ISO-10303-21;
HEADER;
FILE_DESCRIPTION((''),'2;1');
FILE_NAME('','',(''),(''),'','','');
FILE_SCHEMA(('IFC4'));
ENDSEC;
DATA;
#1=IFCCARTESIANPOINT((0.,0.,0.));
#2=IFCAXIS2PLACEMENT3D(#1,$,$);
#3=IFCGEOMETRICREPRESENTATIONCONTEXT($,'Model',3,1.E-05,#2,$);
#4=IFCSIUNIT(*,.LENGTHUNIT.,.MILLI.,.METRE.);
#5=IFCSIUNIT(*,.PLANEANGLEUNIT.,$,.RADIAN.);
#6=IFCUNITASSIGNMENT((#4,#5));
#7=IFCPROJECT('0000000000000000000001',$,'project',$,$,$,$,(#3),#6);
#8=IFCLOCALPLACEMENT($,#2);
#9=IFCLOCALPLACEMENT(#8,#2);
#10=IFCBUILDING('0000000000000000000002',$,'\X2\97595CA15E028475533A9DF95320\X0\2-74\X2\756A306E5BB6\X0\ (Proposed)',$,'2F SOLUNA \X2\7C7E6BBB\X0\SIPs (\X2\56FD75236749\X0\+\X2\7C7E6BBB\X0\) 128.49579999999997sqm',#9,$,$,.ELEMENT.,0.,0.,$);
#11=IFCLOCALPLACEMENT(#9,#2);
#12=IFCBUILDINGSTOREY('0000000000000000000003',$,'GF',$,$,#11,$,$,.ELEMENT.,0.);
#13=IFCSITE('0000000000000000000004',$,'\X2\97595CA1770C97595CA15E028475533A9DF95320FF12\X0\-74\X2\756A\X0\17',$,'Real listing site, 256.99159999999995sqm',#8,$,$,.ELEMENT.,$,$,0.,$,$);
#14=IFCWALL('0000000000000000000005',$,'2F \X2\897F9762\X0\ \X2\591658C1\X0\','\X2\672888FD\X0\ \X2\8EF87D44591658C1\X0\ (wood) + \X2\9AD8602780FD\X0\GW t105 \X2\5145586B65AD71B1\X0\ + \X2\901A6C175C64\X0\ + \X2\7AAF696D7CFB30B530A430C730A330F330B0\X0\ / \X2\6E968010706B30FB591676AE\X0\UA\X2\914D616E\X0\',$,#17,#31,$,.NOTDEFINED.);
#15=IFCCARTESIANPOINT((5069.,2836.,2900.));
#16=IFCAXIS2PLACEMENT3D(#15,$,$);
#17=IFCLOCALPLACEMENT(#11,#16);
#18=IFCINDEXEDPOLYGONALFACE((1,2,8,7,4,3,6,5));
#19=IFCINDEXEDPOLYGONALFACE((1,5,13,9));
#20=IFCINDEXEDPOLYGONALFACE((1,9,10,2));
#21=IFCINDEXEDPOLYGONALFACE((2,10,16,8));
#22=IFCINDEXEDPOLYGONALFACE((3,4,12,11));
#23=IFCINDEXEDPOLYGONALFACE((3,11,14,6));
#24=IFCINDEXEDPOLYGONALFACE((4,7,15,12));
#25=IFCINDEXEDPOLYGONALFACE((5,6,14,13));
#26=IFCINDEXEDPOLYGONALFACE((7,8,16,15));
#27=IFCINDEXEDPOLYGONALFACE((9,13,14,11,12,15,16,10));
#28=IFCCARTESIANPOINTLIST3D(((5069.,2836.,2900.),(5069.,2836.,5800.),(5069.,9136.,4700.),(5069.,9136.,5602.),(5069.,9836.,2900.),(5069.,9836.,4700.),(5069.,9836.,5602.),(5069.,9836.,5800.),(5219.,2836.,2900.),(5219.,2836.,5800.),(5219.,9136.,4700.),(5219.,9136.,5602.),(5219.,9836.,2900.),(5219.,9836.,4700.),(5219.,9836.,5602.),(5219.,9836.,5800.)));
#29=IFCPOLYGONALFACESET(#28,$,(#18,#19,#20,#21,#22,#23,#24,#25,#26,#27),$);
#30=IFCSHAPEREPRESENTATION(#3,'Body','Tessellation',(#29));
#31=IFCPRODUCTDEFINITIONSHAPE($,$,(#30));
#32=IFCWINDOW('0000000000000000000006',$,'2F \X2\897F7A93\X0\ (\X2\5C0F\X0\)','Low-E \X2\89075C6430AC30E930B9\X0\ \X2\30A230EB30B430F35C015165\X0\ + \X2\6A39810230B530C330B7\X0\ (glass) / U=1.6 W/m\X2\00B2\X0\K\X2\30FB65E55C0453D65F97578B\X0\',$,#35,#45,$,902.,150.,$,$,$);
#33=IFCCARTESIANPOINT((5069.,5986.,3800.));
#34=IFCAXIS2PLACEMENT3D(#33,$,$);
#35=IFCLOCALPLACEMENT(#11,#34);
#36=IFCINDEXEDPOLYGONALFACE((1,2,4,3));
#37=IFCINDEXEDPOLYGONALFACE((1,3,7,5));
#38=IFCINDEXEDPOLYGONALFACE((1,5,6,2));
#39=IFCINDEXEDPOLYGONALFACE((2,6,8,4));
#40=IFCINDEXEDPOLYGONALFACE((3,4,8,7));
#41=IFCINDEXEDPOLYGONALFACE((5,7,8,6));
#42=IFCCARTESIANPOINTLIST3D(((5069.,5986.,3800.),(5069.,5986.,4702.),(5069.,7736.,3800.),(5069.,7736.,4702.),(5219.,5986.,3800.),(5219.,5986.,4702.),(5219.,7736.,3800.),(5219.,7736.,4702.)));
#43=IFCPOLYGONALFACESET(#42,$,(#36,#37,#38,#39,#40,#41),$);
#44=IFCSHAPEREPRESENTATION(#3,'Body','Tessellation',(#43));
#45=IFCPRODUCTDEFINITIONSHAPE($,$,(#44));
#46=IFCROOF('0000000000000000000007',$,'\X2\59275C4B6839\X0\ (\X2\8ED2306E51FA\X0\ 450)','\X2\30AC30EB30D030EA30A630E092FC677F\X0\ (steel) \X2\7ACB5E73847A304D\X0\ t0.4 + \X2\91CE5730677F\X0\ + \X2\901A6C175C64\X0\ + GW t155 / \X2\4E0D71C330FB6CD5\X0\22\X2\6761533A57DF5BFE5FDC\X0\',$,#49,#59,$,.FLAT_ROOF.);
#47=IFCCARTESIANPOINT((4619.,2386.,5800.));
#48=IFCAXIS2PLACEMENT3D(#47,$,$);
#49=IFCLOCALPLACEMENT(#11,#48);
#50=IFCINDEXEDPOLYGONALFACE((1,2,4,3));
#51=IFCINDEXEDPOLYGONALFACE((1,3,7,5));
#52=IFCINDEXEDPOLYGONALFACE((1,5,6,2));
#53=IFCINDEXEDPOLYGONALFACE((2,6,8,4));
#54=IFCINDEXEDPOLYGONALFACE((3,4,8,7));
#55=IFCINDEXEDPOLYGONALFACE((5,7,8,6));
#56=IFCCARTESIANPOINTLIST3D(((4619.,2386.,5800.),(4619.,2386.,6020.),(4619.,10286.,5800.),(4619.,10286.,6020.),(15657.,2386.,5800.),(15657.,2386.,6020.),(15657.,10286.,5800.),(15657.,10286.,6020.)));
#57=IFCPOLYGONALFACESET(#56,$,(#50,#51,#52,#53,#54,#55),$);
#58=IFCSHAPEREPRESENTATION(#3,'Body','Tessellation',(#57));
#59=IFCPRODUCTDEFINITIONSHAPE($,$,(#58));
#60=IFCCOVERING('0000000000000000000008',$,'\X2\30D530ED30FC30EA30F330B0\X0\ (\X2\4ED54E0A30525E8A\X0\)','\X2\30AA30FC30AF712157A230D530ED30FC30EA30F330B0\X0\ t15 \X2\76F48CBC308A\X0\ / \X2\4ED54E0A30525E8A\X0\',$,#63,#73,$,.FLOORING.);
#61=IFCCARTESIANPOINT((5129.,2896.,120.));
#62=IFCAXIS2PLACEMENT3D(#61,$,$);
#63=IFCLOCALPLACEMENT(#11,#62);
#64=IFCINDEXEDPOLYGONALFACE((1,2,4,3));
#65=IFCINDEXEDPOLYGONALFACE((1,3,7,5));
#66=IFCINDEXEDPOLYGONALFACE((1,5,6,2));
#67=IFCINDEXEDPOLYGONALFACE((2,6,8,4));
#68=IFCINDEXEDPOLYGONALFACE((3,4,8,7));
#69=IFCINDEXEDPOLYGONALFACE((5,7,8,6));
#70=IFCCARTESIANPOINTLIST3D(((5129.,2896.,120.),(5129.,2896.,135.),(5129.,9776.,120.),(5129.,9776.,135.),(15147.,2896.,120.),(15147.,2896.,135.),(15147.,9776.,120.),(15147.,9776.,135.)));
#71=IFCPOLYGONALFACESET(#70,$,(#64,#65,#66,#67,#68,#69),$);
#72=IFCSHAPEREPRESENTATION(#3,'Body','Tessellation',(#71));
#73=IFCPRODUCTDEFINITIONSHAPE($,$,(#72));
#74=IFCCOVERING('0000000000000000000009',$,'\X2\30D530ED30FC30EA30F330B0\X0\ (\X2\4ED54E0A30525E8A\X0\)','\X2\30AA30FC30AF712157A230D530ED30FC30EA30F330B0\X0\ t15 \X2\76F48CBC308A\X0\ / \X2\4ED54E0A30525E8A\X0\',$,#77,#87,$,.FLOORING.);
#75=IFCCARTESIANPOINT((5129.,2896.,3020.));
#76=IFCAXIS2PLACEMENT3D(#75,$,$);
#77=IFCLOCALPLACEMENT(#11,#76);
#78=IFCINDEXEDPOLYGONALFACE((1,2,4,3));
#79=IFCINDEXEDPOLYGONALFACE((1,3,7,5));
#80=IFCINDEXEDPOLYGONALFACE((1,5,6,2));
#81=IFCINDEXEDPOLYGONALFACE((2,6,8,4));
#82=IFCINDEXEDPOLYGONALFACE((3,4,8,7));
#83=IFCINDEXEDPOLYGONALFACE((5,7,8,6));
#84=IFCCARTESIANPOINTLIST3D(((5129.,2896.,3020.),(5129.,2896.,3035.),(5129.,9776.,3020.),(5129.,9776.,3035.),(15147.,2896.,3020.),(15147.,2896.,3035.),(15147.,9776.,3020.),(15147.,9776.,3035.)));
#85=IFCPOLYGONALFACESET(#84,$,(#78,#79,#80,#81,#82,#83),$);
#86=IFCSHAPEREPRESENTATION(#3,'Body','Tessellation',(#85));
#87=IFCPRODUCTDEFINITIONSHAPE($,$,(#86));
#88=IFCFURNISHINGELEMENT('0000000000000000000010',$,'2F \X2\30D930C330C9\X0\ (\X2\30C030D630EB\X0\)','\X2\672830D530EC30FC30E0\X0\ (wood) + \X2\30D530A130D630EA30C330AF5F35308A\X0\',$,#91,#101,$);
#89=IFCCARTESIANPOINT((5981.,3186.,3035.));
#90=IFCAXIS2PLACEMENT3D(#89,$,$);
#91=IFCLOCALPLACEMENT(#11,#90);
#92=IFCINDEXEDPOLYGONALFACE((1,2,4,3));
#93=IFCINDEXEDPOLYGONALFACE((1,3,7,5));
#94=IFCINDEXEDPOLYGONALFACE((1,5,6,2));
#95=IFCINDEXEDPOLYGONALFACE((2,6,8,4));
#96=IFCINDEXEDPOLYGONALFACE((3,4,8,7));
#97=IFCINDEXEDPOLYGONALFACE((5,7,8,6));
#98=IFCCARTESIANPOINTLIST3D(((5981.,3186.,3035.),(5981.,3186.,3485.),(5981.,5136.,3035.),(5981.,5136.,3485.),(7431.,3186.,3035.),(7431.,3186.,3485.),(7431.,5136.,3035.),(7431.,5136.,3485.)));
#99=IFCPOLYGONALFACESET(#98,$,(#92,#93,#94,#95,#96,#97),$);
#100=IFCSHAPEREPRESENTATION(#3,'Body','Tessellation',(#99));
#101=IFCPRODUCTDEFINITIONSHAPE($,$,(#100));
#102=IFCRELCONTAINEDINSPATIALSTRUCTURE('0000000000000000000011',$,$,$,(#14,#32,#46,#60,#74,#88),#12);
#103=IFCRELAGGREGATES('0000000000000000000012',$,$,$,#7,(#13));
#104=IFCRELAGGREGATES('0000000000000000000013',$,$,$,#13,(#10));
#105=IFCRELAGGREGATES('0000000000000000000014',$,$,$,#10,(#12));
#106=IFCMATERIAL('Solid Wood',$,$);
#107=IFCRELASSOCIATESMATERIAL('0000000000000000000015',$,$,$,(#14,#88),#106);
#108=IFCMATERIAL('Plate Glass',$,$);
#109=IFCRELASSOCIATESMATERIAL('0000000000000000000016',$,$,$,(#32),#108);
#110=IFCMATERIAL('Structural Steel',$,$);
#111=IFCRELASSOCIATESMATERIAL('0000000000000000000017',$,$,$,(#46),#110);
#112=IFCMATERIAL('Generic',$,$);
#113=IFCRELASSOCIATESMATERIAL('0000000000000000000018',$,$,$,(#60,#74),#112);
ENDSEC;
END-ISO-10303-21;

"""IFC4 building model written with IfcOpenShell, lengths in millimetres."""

from ifc_helpers import new_model, si_unit, frame, frame_2d, origin, place, context, project, spatial, rectangle, extrude, material, element, fill, save


model = new_model("IFC4")

# Units and contexts
model_context = context("Model", 3, precision=1e-05, world=origin())
ifc_project = project(units=[si_unit("LENGTHUNIT", "METRE", prefix="MILLI"), si_unit("PLANEANGLEUNIT", "RADIAN")], contexts=[model_context])

# Site, building, storey
site_placement = place(None, origin())
site = spatial("IfcSite", under=ifc_project, at=site_placement, Name="静岡県静岡市葵区鷹匠２-74番17", ObjectType="Real listing site, 256.99159999999995sqm", CompositionType="ELEMENT", RefElevation=0.0)
building_placement = place(site_placement, origin())
building = spatial("IfcBuilding", under=site, at=building_placement, Name="静岡市葵区鷹匠2-74番の家 (Proposed)", ObjectType="2F SOLUNA 籾殻SIPs (国産杉+籾殻) 128.49579999999997sqm", CompositionType="ELEMENT", ElevationOfRefHeight=0.0, ElevationOfTerrain=0.0)
storey_placement = place(building_placement, origin())
storey = spatial("IfcBuildingStorey", under=building, at=storey_placement, Name="GF", CompositionType="ELEMENT", Elevation=0.0)

# Shared definitions
ifc_material_1 = material(Name="Solid Wood")

# Shared definitions
ifc_material_2 = material(Name="Plate Glass")

# Wall, opening, window
wall_1_placement = place(storey_placement, frame((5069.0, 2836.0, 2900.0)))
wall_1 = element("IfcWall", 1, at=wall_1_placement, inside=storey, material=ifc_material_1, Name="2F 西面 外壁", Description="木製 軸組外壁 (wood) + 高性能GW t105 充填断熱 + 通気層 + 窯業系サイディング / 準耐火・外皮UA配慮", PredefinedType="NOTDEFINED", context=model_context, shape_type="SweptSolid", body=[
    extrude(rectangle(XDim=150.0, YDim=7000.0, at=frame_2d((75.0, 3500.0))), frame((5069.0, 2836.0, 2900.0)), (0.0, 0.0, 1.0), 2900.0),
])
opening_1_placement = place(storey_placement, frame((5069.0, 5986.0, 3800.0)))
opening_1 = element("IfcOpeningElement", 2, at=opening_1_placement, cuts=wall_1, PredefinedType="NOTDEFINED", context=model_context, shape_type="SweptSolid", body=[
    extrude(rectangle(XDim=150.0, YDim=1750.0, at=frame_2d((75.0, 875.0))), frame((5069.0, 5986.0, 3800.0)), (0.0, 0.0, 1.0), 902.0),
])
window_1_placement = place(storey_placement, frame((5069.0, 5986.0, 3800.0)))
window_1 = element("IfcWindow", 3, at=window_1_placement, inside=storey, material=ifc_material_2, Name="2F 西窓 (小)", Description="Low-E 複層ガラス アルゴン封入 + 樹脂サッシ (glass) / U=1.6 W/m²K・日射取得型", OverallHeight=902.0, OverallWidth=150.0, context=model_context, shape_type="SweptSolid", body=[
    extrude(rectangle(XDim=150.0, YDim=1750.0, at=frame_2d((75.0, 875.0))), frame((5069.0, 5986.0, 3800.0)), (0.0, 0.0, 1.0), 902.0),
])
fill(opening_1, window_1)

# Roof
ifc_material_3 = material(Name="Structural Steel")
roof_placement = place(storey_placement, frame((4619.0, 2386.0, 5800.0)))
element("IfcRoof", 4, at=roof_placement, inside=storey, material=ifc_material_3, Name="大屋根 (軒の出 450)", Description="ガルバリウム鋼板 (steel) 立平葺き t0.4 + 野地板 + 通気層 + GW t155 / 不燃・法22条区域対応", PredefinedType="FLAT_ROOF", context=model_context, shape_type="SweptSolid", body=[
    extrude(rectangle(XDim=11038.0, YDim=7900.0, at=frame_2d((5519.0, 3950.0))), frame((4619.0, 2386.0, 5800.0)), (0.0, 0.0, 1.0), 220.0),
])

# Coverings
ifc_material_4 = material(Name="Generic")
covering_1_placement = place(storey_placement, frame((5129.0, 2896.0, 120.0)))
element("IfcCovering", 5, at=covering_1_placement, inside=storey, material=ifc_material_4, Name="フローリング (仕上げ床)", Description="オーク無垢フローリング t15 直貼り / 仕上げ床", PredefinedType="FLOORING", context=model_context, shape_type="SweptSolid", body=[
    extrude(rectangle(XDim=10018.0, YDim=6880.0, at=frame_2d((5009.0, 3440.0))), frame((5129.0, 2896.0, 120.0)), (0.0, 0.0, 1.0), 15.0),
])
covering_2_placement = place(storey_placement, frame((5129.0, 2896.0, 3020.0)))
element("IfcCovering", 6, at=covering_2_placement, inside=storey, material=ifc_material_4, Name="フローリング (仕上げ床)", Description="オーク無垢フローリング t15 直貼り / 仕上げ床", PredefinedType="FLOORING", context=model_context, shape_type="SweptSolid", body=[
    extrude(rectangle(XDim=10018.0, YDim=6880.0, at=frame_2d((5009.0, 3440.0))), frame((5129.0, 2896.0, 3020.0)), (0.0, 0.0, 1.0), 15.0),
])

# Furnishing element
furnishing_placement = place(storey_placement, frame((5981.0, 3186.0, 3035.0)))
element("IfcFurnishingElement", 7, at=furnishing_placement, inside=storey, material=ifc_material_1, Name="2F ベッド (ダブル)", Description="木フレーム (wood) + ファブリック張り", context=model_context, shape_type="SweptSolid", body=[
    extrude(rectangle(XDim=1450.0, YDim=1950.0, at=frame_2d((725.0, 975.0))), frame((5981.0, 3186.0, 3035.0)), (0.0, 0.0, 1.0), 450.0),
])

save(model, "model.ifc")
